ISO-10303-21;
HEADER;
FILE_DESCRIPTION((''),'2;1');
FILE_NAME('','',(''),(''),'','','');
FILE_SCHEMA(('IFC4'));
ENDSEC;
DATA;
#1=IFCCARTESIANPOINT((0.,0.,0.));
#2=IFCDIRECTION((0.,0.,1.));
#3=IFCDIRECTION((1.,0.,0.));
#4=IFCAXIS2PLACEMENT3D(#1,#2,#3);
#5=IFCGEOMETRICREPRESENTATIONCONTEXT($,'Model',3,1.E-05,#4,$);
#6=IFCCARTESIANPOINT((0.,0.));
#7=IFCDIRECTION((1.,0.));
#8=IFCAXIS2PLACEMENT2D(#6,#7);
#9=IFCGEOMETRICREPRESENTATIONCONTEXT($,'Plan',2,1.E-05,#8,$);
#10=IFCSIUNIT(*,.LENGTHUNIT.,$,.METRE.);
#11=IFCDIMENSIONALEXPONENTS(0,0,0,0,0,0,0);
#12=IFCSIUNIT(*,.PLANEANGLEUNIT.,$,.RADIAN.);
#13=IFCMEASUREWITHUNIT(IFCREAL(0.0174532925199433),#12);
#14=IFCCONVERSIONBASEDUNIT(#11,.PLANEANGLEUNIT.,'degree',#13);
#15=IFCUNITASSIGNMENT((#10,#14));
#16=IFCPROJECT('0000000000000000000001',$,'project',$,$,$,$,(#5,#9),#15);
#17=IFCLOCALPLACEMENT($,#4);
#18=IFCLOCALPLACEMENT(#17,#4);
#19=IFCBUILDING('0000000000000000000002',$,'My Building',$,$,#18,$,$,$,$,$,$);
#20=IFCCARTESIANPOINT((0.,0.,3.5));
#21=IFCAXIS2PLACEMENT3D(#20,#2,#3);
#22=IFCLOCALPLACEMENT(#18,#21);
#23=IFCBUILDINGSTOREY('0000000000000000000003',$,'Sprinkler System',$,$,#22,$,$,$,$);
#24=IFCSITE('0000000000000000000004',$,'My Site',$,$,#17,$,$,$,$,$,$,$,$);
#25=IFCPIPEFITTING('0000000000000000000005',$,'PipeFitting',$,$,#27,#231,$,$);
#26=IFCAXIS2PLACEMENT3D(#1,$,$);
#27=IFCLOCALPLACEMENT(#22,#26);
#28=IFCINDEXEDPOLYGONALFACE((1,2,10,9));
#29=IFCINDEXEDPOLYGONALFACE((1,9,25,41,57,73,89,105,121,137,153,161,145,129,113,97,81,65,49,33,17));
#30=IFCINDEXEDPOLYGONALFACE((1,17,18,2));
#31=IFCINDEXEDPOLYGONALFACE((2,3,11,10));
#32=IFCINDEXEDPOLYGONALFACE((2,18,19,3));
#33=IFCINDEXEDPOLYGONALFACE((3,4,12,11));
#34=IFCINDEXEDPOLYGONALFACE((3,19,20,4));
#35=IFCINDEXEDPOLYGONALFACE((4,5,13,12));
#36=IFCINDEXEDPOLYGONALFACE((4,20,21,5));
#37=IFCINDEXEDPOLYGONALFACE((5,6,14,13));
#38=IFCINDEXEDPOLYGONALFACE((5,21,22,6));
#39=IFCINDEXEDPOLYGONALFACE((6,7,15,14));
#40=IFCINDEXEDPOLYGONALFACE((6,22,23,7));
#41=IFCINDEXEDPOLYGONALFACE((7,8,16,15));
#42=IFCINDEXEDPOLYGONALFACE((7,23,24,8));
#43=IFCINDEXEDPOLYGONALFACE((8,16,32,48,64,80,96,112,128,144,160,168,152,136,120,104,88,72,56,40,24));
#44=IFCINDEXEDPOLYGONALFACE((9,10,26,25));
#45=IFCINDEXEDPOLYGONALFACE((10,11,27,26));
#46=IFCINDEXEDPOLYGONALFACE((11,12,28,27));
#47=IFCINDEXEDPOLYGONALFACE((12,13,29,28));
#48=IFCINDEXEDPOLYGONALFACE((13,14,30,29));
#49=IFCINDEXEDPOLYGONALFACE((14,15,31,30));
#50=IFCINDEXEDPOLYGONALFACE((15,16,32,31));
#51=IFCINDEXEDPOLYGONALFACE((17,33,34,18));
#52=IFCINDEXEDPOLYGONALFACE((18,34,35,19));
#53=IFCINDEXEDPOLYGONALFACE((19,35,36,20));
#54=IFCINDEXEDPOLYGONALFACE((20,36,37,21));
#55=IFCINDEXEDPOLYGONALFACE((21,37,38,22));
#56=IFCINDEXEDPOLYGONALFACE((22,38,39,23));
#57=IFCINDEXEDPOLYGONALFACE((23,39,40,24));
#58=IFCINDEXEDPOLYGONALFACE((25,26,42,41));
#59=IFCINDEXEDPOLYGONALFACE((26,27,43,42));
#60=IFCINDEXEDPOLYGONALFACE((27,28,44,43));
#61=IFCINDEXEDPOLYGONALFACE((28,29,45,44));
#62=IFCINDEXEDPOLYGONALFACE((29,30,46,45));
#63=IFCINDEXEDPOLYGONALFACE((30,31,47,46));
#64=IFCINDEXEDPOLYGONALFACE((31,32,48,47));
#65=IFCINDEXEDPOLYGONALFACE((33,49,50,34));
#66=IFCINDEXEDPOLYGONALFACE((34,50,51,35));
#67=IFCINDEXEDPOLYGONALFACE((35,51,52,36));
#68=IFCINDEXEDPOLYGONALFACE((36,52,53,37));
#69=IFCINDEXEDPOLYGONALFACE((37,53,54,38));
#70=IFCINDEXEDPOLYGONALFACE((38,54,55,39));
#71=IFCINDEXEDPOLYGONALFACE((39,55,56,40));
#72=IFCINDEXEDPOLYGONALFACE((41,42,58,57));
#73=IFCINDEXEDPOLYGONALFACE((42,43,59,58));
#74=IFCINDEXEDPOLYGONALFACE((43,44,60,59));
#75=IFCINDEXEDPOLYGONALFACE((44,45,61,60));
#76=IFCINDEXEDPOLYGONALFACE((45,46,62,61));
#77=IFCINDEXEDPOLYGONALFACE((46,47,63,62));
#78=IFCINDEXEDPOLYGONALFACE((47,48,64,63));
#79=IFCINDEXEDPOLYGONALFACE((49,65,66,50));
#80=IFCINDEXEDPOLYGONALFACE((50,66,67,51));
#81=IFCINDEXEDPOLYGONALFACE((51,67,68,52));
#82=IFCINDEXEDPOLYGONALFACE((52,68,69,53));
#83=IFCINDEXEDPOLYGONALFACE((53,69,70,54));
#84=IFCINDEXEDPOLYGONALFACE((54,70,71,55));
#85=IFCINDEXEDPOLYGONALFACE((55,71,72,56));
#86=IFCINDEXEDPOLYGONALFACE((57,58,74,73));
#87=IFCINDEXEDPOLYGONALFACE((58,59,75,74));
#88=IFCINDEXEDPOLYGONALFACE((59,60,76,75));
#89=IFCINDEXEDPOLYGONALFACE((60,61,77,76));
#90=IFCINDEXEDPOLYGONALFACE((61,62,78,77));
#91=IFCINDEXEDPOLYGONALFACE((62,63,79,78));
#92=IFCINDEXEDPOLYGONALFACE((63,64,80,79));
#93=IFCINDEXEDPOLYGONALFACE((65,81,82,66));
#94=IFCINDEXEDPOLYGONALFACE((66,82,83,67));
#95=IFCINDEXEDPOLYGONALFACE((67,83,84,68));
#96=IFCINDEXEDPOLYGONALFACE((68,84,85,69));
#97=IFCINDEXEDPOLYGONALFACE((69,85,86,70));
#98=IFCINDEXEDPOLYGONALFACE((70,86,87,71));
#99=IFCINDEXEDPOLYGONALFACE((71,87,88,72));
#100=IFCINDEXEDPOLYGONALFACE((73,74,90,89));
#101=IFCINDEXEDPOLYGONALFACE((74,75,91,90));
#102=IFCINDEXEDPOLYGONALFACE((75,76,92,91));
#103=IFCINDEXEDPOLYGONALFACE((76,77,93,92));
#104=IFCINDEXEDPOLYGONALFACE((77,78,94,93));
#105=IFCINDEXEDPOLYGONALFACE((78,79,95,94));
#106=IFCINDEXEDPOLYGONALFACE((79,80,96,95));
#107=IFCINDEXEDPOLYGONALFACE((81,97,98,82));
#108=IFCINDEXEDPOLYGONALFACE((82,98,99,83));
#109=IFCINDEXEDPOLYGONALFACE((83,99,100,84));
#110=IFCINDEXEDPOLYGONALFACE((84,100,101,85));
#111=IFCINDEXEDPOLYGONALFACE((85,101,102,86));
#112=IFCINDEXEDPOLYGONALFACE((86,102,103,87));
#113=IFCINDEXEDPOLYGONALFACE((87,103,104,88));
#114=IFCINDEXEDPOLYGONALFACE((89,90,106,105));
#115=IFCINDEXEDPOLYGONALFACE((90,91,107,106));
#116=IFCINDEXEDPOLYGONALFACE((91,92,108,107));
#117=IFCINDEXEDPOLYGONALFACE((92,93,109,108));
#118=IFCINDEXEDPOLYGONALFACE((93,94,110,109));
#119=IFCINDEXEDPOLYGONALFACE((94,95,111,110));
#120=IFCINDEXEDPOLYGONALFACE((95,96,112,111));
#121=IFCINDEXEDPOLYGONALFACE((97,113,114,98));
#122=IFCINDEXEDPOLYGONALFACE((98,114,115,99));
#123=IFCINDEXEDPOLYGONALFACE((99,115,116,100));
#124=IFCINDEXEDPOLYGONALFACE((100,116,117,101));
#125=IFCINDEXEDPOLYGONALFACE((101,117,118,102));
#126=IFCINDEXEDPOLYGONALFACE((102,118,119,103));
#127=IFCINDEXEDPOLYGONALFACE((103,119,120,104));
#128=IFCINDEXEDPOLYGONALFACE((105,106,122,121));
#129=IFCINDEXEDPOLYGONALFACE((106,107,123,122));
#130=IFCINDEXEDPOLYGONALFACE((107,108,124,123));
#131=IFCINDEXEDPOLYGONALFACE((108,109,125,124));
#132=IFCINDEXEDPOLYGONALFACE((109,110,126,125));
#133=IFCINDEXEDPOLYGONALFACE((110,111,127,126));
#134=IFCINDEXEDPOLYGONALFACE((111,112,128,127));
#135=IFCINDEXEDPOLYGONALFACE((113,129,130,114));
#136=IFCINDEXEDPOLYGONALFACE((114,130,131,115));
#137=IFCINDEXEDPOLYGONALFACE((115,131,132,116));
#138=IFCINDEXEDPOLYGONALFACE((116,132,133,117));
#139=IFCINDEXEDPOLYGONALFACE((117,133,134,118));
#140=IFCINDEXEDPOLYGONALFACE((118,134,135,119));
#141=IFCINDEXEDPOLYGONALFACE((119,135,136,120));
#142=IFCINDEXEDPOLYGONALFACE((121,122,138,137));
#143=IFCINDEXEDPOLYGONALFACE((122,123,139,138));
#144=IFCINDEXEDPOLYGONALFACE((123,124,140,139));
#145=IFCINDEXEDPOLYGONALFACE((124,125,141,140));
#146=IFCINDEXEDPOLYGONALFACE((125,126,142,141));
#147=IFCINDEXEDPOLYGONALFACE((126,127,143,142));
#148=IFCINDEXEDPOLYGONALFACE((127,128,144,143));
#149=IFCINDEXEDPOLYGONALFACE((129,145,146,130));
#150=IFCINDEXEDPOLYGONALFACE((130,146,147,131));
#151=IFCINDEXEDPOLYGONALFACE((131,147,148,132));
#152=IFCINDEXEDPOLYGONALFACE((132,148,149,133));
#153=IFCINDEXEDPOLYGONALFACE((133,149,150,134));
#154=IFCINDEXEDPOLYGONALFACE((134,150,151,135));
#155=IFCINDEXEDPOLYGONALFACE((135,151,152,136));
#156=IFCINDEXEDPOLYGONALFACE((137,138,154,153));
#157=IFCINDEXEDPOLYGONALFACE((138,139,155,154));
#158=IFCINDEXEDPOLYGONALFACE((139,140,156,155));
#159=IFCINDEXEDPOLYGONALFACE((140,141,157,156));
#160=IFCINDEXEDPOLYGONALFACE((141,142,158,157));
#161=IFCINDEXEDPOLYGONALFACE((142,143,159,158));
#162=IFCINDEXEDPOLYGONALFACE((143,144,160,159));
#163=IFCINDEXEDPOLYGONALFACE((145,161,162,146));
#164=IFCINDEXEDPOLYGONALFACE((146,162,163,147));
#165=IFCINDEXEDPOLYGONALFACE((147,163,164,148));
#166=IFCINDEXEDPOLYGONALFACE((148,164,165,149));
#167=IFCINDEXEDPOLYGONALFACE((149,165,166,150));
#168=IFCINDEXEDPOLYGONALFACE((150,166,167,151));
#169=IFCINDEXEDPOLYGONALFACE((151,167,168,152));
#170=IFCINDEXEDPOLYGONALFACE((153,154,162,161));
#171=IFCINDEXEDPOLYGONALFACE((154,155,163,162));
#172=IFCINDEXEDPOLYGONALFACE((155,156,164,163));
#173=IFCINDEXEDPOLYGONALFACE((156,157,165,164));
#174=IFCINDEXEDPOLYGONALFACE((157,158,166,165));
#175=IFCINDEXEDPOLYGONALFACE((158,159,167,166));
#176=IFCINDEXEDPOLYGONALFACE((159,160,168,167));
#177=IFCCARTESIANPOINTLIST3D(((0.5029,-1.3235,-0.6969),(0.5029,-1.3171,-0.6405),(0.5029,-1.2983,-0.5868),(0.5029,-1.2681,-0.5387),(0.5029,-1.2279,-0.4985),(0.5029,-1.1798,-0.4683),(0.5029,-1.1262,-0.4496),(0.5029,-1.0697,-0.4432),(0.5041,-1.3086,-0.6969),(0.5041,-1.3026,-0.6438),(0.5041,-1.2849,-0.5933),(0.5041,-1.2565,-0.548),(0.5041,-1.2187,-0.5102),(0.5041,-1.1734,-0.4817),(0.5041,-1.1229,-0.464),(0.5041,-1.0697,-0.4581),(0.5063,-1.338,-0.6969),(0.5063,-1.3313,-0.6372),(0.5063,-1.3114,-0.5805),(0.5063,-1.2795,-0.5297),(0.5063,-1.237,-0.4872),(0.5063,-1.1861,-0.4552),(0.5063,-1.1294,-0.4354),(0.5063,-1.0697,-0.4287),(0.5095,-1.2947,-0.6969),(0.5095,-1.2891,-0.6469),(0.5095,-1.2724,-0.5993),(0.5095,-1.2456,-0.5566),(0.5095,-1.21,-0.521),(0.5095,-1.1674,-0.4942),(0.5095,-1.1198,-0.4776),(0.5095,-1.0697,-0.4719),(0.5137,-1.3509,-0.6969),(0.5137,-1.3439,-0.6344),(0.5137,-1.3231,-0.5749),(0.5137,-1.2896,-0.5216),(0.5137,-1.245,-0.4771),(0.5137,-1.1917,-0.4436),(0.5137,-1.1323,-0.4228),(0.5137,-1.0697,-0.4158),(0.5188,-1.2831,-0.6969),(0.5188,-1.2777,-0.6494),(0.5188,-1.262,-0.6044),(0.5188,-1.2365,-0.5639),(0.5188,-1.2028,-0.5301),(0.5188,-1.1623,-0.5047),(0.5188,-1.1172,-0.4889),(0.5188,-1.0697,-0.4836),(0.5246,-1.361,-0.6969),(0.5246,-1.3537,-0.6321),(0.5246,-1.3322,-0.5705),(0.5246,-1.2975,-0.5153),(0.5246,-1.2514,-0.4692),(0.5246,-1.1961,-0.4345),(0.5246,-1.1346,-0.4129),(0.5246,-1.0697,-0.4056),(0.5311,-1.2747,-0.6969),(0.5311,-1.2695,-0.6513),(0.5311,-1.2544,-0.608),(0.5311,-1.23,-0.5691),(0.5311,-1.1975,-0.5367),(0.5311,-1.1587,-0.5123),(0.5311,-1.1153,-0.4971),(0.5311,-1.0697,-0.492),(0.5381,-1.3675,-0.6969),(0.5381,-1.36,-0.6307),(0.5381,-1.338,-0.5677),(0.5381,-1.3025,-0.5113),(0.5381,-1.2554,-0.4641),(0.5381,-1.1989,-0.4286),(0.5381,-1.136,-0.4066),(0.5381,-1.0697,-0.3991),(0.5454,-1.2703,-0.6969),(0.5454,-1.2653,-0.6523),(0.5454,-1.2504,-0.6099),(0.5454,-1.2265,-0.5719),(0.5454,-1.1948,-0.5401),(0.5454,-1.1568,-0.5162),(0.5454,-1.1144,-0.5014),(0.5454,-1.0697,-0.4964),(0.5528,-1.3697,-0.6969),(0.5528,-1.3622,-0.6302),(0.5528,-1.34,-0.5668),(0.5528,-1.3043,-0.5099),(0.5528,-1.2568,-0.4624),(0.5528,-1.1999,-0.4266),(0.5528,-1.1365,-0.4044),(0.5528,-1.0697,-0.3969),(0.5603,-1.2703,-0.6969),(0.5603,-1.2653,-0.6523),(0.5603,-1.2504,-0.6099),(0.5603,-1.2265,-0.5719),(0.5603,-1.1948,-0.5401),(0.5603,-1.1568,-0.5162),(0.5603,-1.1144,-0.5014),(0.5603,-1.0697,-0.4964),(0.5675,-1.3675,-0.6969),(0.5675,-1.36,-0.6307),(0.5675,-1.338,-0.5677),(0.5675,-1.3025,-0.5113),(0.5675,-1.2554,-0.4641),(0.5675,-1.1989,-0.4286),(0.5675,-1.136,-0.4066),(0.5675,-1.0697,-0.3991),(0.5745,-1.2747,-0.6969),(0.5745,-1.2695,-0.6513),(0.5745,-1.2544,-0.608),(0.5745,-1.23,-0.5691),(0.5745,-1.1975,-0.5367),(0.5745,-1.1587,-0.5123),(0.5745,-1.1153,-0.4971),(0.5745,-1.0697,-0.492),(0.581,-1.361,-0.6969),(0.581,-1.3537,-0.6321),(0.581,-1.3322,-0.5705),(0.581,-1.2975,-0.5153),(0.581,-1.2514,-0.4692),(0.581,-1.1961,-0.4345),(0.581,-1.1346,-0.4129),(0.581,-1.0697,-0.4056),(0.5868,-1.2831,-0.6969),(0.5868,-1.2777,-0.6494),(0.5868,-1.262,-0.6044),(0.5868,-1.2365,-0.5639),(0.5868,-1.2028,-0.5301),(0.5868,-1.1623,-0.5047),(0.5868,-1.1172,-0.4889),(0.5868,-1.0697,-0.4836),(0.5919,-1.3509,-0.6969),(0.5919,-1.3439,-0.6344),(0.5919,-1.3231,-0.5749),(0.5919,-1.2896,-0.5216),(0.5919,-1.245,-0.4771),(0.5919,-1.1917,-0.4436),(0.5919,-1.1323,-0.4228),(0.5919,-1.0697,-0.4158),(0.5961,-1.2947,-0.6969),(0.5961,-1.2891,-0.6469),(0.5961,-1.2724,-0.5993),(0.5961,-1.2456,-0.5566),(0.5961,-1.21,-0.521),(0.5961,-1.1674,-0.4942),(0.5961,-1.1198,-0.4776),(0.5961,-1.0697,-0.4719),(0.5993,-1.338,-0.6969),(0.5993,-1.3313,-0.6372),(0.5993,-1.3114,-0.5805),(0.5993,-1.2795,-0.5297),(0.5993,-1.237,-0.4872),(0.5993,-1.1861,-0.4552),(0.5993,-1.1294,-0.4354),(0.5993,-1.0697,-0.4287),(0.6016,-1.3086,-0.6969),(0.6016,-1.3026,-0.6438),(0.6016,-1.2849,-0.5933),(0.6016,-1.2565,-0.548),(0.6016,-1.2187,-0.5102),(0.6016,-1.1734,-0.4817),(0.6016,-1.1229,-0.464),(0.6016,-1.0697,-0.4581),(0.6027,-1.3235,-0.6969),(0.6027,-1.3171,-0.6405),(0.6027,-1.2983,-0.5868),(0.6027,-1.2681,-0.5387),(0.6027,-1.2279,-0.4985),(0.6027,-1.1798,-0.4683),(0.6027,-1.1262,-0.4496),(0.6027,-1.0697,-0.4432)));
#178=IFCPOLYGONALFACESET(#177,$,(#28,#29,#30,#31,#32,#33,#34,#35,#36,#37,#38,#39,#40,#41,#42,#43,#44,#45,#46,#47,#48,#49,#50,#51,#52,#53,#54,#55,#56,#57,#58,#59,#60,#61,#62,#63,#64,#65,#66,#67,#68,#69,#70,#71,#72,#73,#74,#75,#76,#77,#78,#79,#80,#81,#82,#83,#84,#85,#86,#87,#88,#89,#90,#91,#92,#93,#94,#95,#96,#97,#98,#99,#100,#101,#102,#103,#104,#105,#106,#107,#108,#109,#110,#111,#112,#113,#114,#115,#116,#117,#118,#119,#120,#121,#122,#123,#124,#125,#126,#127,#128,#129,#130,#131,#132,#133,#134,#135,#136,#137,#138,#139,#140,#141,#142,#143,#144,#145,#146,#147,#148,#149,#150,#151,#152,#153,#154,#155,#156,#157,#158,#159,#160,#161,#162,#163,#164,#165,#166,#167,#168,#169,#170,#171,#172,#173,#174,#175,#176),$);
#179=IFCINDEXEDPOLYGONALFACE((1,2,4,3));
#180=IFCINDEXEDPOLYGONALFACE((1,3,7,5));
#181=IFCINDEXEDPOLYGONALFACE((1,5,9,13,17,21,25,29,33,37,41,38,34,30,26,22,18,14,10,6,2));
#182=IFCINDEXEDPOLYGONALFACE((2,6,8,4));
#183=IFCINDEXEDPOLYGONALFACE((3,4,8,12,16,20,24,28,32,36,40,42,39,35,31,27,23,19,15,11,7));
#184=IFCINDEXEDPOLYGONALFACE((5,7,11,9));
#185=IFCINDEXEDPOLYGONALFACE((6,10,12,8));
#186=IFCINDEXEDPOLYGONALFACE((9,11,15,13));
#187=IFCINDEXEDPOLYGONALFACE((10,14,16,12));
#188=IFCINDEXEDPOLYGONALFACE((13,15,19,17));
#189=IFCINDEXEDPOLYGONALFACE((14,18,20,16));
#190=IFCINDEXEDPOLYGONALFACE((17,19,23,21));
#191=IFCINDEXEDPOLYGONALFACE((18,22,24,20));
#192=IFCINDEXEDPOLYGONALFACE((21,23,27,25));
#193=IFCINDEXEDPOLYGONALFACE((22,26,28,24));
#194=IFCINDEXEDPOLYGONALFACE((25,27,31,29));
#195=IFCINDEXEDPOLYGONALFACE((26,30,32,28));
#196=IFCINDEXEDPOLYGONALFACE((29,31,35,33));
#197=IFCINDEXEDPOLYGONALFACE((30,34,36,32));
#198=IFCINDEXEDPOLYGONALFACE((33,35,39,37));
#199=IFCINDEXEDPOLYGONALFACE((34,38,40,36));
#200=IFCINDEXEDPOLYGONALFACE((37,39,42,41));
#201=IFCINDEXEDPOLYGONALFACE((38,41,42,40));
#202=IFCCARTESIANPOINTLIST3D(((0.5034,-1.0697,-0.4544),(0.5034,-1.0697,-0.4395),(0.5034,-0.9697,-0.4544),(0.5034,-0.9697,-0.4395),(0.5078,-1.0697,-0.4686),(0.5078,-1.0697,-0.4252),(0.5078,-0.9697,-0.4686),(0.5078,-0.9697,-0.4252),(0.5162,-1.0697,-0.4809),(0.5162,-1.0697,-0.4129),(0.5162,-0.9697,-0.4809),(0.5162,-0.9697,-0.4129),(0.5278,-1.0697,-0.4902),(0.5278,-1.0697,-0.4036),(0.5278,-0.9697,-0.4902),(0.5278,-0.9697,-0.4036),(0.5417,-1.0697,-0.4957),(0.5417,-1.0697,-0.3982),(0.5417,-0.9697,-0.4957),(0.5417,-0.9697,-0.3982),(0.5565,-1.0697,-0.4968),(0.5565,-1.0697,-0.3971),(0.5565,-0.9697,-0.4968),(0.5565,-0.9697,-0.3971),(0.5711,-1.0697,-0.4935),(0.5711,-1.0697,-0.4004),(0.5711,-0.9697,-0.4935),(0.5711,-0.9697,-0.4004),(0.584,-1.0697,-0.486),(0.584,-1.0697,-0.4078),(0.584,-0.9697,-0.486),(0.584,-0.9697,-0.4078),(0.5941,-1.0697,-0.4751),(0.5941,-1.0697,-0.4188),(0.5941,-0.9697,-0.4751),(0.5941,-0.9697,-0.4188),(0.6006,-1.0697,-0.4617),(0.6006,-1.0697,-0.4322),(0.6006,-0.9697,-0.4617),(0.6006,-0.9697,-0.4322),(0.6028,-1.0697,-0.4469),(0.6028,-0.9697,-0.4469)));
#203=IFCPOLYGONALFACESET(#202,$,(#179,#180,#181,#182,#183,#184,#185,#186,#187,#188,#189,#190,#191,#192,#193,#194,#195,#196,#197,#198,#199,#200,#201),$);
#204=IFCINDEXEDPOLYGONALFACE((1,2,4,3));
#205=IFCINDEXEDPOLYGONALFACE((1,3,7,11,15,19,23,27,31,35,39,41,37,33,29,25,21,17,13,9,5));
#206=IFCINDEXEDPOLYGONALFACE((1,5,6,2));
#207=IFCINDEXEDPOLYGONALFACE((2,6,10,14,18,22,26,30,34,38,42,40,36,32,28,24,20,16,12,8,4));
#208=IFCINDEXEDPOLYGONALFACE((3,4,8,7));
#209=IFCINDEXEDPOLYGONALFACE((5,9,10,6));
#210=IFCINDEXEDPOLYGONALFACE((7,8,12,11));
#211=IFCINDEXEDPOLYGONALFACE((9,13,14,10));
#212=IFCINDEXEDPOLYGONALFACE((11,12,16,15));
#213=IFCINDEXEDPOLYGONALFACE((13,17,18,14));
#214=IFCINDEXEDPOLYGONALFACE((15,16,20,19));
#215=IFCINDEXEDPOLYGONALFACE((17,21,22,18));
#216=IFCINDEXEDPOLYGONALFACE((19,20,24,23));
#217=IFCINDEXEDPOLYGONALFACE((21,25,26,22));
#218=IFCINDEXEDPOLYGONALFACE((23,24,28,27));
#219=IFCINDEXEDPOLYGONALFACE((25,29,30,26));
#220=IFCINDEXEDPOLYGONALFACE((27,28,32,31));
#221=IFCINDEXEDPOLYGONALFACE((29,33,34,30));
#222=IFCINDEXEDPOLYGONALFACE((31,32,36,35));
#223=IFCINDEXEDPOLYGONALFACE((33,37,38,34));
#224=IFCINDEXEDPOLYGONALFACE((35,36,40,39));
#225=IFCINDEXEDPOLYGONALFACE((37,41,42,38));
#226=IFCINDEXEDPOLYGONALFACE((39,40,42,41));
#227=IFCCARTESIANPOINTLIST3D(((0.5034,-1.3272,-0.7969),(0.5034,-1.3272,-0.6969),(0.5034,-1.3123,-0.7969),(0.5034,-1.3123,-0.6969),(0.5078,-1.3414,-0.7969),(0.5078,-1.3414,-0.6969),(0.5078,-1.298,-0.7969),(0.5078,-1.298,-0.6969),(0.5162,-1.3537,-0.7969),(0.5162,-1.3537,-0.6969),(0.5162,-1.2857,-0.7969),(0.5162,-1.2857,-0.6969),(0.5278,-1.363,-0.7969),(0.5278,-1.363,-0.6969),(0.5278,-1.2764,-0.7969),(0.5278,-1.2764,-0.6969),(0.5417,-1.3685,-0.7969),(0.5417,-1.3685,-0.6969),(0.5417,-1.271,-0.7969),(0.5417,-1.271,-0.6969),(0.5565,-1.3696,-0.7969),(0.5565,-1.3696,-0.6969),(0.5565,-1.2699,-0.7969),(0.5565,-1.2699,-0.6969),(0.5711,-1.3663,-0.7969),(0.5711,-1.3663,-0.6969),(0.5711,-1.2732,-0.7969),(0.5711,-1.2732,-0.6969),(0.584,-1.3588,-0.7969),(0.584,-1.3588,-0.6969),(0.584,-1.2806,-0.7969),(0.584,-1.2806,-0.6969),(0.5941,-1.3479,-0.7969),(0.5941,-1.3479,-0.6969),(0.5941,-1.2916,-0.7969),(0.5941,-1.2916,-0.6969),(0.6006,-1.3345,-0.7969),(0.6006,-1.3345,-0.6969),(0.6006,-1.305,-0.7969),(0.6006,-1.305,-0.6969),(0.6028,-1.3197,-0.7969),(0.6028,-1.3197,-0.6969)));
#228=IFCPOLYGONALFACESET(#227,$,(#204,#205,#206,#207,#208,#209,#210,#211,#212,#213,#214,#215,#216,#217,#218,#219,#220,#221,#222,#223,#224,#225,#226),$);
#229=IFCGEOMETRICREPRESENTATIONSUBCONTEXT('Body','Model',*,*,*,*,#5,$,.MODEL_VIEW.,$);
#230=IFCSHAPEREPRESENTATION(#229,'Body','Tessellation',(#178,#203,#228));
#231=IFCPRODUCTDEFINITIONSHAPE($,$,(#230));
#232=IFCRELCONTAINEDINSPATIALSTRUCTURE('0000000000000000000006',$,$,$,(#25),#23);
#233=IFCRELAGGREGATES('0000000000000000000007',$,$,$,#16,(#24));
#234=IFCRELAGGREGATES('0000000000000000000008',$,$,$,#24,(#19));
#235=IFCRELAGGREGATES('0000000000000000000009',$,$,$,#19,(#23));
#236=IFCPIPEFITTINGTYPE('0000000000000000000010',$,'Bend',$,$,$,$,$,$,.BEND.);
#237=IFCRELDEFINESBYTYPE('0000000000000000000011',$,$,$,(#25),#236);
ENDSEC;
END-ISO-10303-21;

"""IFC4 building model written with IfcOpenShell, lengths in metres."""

from ifc_helpers import new_model, entity, si_unit, converted_unit, frame, origin_with_axes, origin_2d_with_axis, place, context, subcontext, project, spatial, circle, extrude, source, transform, mapped, type_object, type_shapes, element, save


model = new_model("IFC4")

# Units and contexts
model_context = context("Model", 3, precision=1e-05, world=origin_with_axes())
plan_context = context("Plan", 2, precision=1e-05, world=origin_2d_with_axis())
body_context = subcontext(model_context, "Body", "Model", "MODEL_VIEW")
ifc_project = project(units=[si_unit("LENGTHUNIT", "METRE"), converted_unit("PLANEANGLEUNIT", "degree", entity("IfcReal", 0.0174532925199433), si_unit("PLANEANGLEUNIT", "RADIAN"), dimensions=[0, 0, 0, 0, 0, 0, 0])], contexts=[model_context, plan_context])

# Site, building, storey
site_placement = place(None, origin_with_axes())
site = spatial("IfcSite", under=ifc_project, at=site_placement, Name="My Site")
building_placement = place(site_placement, origin_with_axes())
building = spatial("IfcBuilding", under=site, at=building_placement, Name="My Building")
storey_placement = place(building_placement, frame((0.0, 0.0, 3.5), z_axis=(0.0, 0.0, 1.0), x_axis=(1.0, 0.0, 0.0)))
storey = spatial("IfcBuildingStorey", under=building, at=storey_placement, Name="Sprinkler System")

# Pipe fitting
pipe_fitting_type_1 = type_object("IfcPipeFittingType", Name="Bend", PredefinedType="BEND")
shared_shape_1 = source(origin_with_axes(), body_context, "Body", "SolidModel", [
    entity("IfcSweptDiskSolid", entity("IfcIndexedPolyCurve", entity("IfcCartesianPointList3D", [[0.0, 0.0, 0.1], [0.0, -0.0732, 0.2768], [0.0, -0.25, 0.35]]), [entity("IfcArcIndex", [1, 2, 3])]), 0.05),
    extrude(circle(Radius=0.05), origin_with_axes(), (0.0, 0.0, 1.0), 0.1),
    extrude(circle(Radius=0.05), frame((0.0, -0.25, 0.35), z_axis=(0.0, -1.0, 0.000044), x_axis=(1.0, 0.0, 0.0)), (0.0, 0.0, 1.0), 0.1),
])
type_shapes(pipe_fitting_type_1, [shared_shape_1])
for number, where, z_axis, x_axis, name in (
    (1, (0.5528, -0.9697, -0.4469), (0.0, -1.0, -0.00001), (1.0, 0.0, 0.0), "PipeFitting"),
):
    element("IfcPipeFitting", number, at=place(storey_placement, frame(where, z_axis=z_axis, x_axis=x_axis)), inside=storey, type_object=pipe_fitting_type_1, Name=name, context=body_context, shape_type="MappedRepresentation", body=[
        mapped(shared_shape_1, transform((0.0, 0.0, 0.0), x_axis=(1.0, 0.0, 0.0), y_axis=(0.0, 1.0, 0.0), z_axis=(0.0, 0.0, 1.0), scale=1.0)),
    ])

save(model, "model.ifc")
